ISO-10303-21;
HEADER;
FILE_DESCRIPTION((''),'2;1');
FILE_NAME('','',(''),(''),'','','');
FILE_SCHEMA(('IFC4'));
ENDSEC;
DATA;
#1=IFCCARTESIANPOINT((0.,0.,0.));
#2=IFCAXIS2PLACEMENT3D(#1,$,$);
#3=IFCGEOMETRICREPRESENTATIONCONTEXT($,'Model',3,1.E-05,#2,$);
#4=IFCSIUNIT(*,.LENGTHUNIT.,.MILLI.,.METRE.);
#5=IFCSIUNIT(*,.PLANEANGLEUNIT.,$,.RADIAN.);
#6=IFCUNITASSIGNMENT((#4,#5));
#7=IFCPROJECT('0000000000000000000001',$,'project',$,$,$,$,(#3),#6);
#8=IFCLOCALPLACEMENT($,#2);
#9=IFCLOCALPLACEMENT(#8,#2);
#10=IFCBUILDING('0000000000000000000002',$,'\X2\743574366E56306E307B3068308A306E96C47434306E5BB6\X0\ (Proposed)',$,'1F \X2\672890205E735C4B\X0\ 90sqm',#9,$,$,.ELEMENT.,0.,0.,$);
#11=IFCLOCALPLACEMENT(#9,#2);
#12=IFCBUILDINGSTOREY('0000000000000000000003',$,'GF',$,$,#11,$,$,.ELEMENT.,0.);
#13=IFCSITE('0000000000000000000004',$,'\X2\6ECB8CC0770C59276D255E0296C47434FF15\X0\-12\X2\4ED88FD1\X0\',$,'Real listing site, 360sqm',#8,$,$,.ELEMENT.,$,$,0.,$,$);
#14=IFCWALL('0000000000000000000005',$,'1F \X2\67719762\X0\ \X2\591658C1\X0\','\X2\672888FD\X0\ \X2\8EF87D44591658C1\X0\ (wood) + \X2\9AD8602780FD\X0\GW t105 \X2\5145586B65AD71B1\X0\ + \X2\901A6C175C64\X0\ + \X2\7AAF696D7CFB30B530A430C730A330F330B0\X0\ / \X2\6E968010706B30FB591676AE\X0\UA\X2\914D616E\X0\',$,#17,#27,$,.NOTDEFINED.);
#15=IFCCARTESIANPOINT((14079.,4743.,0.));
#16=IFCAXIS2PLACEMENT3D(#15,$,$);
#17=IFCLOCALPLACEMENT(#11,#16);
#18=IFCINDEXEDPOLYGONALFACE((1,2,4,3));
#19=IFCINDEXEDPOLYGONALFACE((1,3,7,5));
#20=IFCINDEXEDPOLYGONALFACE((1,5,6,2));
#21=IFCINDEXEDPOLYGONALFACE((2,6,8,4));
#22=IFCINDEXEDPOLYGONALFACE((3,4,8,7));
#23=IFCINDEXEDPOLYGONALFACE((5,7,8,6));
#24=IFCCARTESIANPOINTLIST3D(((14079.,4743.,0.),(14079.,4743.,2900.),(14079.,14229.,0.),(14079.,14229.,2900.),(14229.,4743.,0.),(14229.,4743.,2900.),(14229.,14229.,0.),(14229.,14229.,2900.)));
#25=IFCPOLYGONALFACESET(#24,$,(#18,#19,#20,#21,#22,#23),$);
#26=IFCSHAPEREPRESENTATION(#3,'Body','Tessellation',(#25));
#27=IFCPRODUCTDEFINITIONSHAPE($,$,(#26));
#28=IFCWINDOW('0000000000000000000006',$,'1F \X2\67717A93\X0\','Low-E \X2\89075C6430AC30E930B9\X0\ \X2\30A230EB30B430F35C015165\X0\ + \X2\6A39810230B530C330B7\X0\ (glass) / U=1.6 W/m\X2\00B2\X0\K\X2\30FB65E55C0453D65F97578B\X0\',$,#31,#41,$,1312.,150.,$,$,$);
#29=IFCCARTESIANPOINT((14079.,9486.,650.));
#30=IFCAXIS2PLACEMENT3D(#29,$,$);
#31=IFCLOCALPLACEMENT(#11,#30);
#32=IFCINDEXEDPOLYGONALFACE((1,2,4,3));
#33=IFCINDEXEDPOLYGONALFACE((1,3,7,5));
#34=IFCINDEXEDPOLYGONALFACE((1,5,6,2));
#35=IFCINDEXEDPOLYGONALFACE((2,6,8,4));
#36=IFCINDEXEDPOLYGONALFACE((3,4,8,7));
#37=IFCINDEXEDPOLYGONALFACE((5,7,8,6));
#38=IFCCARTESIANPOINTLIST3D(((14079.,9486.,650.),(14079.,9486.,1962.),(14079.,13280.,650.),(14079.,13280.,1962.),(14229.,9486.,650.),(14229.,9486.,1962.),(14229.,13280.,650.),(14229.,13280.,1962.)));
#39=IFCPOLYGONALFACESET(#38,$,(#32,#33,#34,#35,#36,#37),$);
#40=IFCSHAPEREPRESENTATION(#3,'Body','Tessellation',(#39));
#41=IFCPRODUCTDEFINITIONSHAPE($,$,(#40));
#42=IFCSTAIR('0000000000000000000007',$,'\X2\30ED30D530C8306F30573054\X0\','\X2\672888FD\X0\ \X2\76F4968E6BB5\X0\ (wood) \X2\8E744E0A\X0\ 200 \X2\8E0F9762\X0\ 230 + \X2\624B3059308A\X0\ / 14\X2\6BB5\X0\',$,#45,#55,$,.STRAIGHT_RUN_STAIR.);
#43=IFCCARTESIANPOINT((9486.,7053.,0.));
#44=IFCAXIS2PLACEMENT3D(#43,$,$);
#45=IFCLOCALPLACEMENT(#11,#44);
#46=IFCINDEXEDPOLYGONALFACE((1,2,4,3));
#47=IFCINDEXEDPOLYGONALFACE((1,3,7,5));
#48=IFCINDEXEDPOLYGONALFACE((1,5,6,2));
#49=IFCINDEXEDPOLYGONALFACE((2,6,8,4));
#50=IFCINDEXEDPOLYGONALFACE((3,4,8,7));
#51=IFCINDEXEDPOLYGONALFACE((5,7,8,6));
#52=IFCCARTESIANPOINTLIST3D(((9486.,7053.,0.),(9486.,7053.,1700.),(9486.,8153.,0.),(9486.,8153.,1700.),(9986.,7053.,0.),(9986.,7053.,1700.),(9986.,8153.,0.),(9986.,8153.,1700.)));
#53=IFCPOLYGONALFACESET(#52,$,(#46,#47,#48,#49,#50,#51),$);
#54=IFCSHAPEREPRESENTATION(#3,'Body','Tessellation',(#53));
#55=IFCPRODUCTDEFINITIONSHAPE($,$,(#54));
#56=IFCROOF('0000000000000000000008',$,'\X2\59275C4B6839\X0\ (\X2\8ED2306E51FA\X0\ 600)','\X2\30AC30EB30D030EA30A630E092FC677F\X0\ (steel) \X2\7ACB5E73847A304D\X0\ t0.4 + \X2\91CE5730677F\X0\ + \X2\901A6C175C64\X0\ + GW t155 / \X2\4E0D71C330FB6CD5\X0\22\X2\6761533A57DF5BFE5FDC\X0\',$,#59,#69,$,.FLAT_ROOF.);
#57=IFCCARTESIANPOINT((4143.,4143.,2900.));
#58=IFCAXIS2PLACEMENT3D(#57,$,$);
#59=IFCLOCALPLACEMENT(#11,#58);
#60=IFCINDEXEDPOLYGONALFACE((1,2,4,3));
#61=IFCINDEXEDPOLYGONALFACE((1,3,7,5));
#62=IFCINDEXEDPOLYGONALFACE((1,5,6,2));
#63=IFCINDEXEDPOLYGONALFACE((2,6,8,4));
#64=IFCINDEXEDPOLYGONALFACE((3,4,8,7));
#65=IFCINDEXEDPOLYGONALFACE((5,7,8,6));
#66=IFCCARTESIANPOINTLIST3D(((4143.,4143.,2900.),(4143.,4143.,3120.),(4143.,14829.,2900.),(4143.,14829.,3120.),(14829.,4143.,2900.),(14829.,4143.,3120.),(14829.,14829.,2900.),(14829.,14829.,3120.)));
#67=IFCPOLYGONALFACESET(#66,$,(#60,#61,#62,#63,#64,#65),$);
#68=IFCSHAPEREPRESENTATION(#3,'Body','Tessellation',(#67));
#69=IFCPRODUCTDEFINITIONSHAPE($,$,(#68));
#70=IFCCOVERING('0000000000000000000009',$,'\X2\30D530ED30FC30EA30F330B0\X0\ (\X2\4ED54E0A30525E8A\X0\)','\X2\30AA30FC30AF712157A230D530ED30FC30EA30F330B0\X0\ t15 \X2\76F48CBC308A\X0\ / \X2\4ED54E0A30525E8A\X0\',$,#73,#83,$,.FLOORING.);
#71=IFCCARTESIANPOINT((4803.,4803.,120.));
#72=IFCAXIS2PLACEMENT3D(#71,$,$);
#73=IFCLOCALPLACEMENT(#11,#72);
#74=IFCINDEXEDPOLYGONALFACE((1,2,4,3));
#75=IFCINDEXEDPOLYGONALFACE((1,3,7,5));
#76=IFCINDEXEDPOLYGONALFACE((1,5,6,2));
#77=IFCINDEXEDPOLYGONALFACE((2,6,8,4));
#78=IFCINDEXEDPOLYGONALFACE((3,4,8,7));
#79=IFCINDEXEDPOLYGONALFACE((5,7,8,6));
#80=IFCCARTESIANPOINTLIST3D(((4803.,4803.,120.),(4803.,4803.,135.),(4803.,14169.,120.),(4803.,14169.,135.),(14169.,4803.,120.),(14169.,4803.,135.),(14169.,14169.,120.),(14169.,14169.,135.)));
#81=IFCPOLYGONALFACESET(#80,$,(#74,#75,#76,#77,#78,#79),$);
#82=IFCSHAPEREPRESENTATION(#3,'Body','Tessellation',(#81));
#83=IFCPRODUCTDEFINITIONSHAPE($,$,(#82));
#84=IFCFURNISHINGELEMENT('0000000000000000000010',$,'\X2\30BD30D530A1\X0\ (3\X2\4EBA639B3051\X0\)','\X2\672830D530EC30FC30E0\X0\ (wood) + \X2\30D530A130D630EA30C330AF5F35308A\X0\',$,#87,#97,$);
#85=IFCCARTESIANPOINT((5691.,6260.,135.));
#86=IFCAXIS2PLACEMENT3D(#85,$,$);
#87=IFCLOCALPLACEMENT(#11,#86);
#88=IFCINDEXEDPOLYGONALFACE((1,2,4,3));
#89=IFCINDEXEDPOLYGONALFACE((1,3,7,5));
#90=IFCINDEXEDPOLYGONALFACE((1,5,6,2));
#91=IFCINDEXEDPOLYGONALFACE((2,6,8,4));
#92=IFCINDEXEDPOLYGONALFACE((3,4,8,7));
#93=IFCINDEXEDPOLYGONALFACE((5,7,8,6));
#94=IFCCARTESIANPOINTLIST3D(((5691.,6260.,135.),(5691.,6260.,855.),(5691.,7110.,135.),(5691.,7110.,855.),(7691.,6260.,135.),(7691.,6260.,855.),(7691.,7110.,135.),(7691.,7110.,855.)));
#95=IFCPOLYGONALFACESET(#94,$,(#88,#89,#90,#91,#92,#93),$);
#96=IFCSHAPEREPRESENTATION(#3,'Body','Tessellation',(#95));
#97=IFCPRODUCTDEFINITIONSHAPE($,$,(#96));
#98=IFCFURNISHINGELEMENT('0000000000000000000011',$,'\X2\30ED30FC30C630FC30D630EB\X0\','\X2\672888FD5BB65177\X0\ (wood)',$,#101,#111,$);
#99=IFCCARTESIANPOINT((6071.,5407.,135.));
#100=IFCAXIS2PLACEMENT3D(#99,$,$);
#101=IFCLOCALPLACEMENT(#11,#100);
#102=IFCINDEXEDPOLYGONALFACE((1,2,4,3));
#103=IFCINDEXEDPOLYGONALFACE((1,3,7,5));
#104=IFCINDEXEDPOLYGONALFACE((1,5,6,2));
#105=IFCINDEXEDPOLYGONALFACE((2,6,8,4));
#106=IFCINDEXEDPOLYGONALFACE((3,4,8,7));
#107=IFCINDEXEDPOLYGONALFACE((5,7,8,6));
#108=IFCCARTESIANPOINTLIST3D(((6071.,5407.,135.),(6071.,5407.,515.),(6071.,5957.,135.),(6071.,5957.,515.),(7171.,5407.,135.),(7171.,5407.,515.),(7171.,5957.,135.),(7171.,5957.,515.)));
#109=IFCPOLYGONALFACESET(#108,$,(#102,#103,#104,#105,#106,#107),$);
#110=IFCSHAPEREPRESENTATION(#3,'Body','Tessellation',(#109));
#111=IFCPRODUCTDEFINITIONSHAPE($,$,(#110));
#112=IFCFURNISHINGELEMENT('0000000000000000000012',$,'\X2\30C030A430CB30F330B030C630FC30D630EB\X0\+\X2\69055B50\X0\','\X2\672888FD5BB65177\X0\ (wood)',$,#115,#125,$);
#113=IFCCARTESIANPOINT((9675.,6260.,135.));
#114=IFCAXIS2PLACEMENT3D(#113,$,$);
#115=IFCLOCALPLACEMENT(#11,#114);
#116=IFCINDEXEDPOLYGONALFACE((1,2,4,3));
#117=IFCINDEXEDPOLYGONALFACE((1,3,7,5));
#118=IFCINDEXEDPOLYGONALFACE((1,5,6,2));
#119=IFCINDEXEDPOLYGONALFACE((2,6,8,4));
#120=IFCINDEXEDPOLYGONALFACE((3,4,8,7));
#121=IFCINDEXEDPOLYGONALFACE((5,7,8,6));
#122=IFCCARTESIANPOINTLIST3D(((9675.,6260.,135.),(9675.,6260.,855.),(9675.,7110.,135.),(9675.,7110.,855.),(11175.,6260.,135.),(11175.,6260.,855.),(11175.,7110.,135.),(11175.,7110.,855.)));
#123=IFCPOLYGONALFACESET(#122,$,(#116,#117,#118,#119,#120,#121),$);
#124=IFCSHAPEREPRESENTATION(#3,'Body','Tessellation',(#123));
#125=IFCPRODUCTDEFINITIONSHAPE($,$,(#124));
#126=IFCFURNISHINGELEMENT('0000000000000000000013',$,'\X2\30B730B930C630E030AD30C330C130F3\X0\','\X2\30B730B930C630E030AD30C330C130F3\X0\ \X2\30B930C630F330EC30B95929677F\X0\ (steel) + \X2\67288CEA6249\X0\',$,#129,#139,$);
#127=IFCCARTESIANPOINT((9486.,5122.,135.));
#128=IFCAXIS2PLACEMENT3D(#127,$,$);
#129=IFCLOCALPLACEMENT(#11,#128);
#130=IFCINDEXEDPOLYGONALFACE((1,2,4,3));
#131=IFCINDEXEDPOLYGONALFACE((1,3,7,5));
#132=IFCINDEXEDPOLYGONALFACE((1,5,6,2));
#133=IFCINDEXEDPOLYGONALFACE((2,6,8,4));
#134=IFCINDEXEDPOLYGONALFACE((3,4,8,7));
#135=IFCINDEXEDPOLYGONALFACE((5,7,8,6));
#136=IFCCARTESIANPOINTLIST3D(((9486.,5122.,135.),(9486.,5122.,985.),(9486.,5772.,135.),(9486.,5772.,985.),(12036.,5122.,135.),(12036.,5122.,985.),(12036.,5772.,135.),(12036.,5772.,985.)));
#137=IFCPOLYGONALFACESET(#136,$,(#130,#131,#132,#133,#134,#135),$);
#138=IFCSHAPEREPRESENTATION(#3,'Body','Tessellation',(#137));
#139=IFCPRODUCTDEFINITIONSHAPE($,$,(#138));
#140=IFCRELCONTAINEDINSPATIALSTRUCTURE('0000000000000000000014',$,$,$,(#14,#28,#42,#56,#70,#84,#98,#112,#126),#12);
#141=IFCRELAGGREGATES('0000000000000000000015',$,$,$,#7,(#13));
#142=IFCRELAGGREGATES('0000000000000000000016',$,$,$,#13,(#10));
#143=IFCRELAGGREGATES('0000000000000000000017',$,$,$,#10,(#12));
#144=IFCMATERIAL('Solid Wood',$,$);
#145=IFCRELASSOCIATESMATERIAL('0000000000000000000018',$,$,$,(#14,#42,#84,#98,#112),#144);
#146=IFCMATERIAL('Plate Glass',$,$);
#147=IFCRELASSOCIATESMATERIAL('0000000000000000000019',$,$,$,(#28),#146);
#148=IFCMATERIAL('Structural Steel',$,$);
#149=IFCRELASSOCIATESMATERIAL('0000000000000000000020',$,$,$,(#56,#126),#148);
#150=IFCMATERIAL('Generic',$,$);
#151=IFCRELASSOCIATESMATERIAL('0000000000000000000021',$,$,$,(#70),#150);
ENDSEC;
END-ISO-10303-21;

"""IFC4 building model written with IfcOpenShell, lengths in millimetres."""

from ifc_helpers import new_model, si_unit, frame, frame_2d, origin, place, context, project, spatial, rectangle, extrude, material, element, fill, save


model = new_model("IFC4")

# Units and contexts
model_context = context("Model", 3, precision=1e-05, world=origin())
ifc_project = project(units=[si_unit("LENGTHUNIT", "METRE", prefix="MILLI"), si_unit("PLANEANGLEUNIT", "RADIAN")], contexts=[model_context])

# Site, building, storey
site_placement = place(None, origin())
site = spatial("IfcSite", under=ifc_project, at=site_placement, Name="滋賀県大津市雄琴５-12付近", ObjectType="Real listing site, 360sqm", CompositionType="ELEMENT", RefElevation=0.0)
building_placement = place(site_placement, origin())
building = spatial("IfcBuilding", under=site, at=building_placement, Name="琵琶湖のほとりの雄琴の家 (Proposed)", ObjectType="1F 木造平屋 90sqm", CompositionType="ELEMENT", ElevationOfRefHeight=0.0, ElevationOfTerrain=0.0)
storey_placement = place(building_placement, origin())
storey = spatial("IfcBuildingStorey", under=building, at=storey_placement, Name="GF", CompositionType="ELEMENT", Elevation=0.0)

# Shared definitions
ifc_material_1 = material(Name="Solid Wood")

# Shared definitions
ifc_material_2 = material(Name="Plate Glass")

# Wall, opening, window
wall_1_placement = place(storey_placement, frame((14079.0, 4743.0, 0.0)))
wall_1 = element("IfcWall", 1, at=wall_1_placement, inside=storey, material=ifc_material_1, Name="1F 東面 外壁", Description="木製 軸組外壁 (wood) + 高性能GW t105 充填断熱 + 通気層 + 窯業系サイディング / 準耐火・外皮UA配慮", PredefinedType="NOTDEFINED", context=model_context, shape_type="SweptSolid", body=[
    extrude(rectangle(XDim=150.0, YDim=9486.0, at=frame_2d((75.0, 4743.0))), frame((14079.0, 4743.0, 0.0)), (0.0, 0.0, 1.0), 2900.0),
])
opening_1_placement = place(storey_placement, frame((14079.0, 9486.0, 650.0)))
opening_1 = element("IfcOpeningElement", 2, at=opening_1_placement, cuts=wall_1, PredefinedType="NOTDEFINED", context=model_context, shape_type="SweptSolid", body=[
    extrude(rectangle(XDim=150.0, YDim=3794.0, at=frame_2d((75.0, 1897.0))), frame((14079.0, 9486.0, 650.0)), (0.0, 0.0, 1.0), 1312.0),
])
window_1_placement = place(storey_placement, frame((14079.0, 9486.0, 650.0)))
window_1 = element("IfcWindow", 3, at=window_1_placement, inside=storey, material=ifc_material_2, Name="1F 東窓", Description="Low-E 複層ガラス アルゴン封入 + 樹脂サッシ (glass) / U=1.6 W/m²K・日射取得型", OverallHeight=1312.0, OverallWidth=150.0, context=model_context, shape_type="SweptSolid", body=[
    extrude(rectangle(XDim=150.0, YDim=3794.0, at=frame_2d((75.0, 1897.0))), frame((14079.0, 9486.0, 650.0)), (0.0, 0.0, 1.0), 1312.0),
])
fill(opening_1, window_1)

# Stair
stair_placement = place(storey_placement, frame((9486.0, 7053.0, 0.0)))
element("IfcStair", 4, at=stair_placement, inside=storey, material=ifc_material_1, Name="ロフトはしご", Description="木製 直階段 (wood) 蹴上 200 踏面 230 + 手すり / 14段", PredefinedType="STRAIGHT_RUN_STAIR", context=model_context, shape_type="SweptSolid", body=[
    extrude(rectangle(XDim=500.0, YDim=1100.0, at=frame_2d((250.0, 550.0))), frame((9486.0, 7053.0, 0.0)), (0.0, 0.0, 1.0), 1700.0),
])

# Roof
ifc_material_3 = material(Name="Structural Steel")
roof_placement = place(storey_placement, frame((4143.0, 4143.0, 2900.0)))
element("IfcRoof", 5, at=roof_placement, inside=storey, material=ifc_material_3, Name="大屋根 (軒の出 600)", Description="ガルバリウム鋼板 (steel) 立平葺き t0.4 + 野地板 + 通気層 + GW t155 / 不燃・法22条区域対応", PredefinedType="FLAT_ROOF", context=model_context, shape_type="SweptSolid", body=[
    extrude(rectangle(XDim=10686.0, YDim=10686.0, at=frame_2d((5343.0, 5343.0))), frame((4143.0, 4143.0, 2900.0)), (0.0, 0.0, 1.0), 220.0),
])

# Covering
ifc_material_4 = material(Name="Generic")
covering_placement = place(storey_placement, frame((4803.0, 4803.0, 120.0)))
element("IfcCovering", 6, at=covering_placement, inside=storey, material=ifc_material_4, Name="フローリング (仕上げ床)", Description="オーク無垢フローリング t15 直貼り / 仕上げ床", PredefinedType="FLOORING", context=model_context, shape_type="SweptSolid", body=[
    extrude(rectangle(XDim=9366.0, YDim=9366.0, at=frame_2d((4683.0, 4683.0))), frame((4803.0, 4803.0, 120.0)), (0.0, 0.0, 1.0), 15.0),
])

# Furnishing elements
furnishing_1_placement = place(storey_placement, frame((5691.0, 6260.0, 135.0)))
element("IfcFurnishingElement", 7, at=furnishing_1_placement, inside=storey, material=ifc_material_1, Name="ソファ (3人掛け)", Description="木フレーム (wood) + ファブリック張り", context=model_context, shape_type="SweptSolid", body=[
    extrude(rectangle(XDim=2000.0, YDim=850.0, at=frame_2d((1000.0, 425.0))), frame((5691.0, 6260.0, 135.0)), (0.0, 0.0, 1.0), 720.0),
])
furnishing_2_placement = place(storey_placement, frame((6071.0, 5407.0, 135.0)))
element("IfcFurnishingElement", 8, at=furnishing_2_placement, inside=storey, material=ifc_material_1, Name="ローテーブル", Description="木製家具 (wood)", context=model_context, shape_type="SweptSolid", body=[
    extrude(rectangle(XDim=1100.0, YDim=550.0, at=frame_2d((550.0, 275.0))), frame((6071.0, 5407.0, 135.0)), (0.0, 0.0, 1.0), 380.0),
])
furnishing_3_placement = place(storey_placement, frame((9675.0, 6260.0, 135.0)))
element("IfcFurnishingElement", 9, at=furnishing_3_placement, inside=storey, material=ifc_material_1, Name="ダイニングテーブル+椅子", Description="木製家具 (wood)", context=model_context, shape_type="SweptSolid", body=[
    extrude(rectangle(XDim=1500.0, YDim=850.0, at=frame_2d((750.0, 425.0))), frame((9675.0, 6260.0, 135.0)), (0.0, 0.0, 1.0), 720.0),
])
furnishing_4_placement = place(storey_placement, frame((9486.0, 5122.0, 135.0)))
element("IfcFurnishingElement", 10, at=furnishing_4_placement, inside=storey, material=ifc_material_3, Name="システムキッチン", Description="システムキッチン ステンレス天板 (steel) + 木質扉", context=model_context, shape_type="SweptSolid", body=[
    extrude(rectangle(XDim=2550.0, YDim=650.0, at=frame_2d((1275.0, 325.0))), frame((9486.0, 5122.0, 135.0)), (0.0, 0.0, 1.0), 850.0),
])

save(model, "model.ifc")
